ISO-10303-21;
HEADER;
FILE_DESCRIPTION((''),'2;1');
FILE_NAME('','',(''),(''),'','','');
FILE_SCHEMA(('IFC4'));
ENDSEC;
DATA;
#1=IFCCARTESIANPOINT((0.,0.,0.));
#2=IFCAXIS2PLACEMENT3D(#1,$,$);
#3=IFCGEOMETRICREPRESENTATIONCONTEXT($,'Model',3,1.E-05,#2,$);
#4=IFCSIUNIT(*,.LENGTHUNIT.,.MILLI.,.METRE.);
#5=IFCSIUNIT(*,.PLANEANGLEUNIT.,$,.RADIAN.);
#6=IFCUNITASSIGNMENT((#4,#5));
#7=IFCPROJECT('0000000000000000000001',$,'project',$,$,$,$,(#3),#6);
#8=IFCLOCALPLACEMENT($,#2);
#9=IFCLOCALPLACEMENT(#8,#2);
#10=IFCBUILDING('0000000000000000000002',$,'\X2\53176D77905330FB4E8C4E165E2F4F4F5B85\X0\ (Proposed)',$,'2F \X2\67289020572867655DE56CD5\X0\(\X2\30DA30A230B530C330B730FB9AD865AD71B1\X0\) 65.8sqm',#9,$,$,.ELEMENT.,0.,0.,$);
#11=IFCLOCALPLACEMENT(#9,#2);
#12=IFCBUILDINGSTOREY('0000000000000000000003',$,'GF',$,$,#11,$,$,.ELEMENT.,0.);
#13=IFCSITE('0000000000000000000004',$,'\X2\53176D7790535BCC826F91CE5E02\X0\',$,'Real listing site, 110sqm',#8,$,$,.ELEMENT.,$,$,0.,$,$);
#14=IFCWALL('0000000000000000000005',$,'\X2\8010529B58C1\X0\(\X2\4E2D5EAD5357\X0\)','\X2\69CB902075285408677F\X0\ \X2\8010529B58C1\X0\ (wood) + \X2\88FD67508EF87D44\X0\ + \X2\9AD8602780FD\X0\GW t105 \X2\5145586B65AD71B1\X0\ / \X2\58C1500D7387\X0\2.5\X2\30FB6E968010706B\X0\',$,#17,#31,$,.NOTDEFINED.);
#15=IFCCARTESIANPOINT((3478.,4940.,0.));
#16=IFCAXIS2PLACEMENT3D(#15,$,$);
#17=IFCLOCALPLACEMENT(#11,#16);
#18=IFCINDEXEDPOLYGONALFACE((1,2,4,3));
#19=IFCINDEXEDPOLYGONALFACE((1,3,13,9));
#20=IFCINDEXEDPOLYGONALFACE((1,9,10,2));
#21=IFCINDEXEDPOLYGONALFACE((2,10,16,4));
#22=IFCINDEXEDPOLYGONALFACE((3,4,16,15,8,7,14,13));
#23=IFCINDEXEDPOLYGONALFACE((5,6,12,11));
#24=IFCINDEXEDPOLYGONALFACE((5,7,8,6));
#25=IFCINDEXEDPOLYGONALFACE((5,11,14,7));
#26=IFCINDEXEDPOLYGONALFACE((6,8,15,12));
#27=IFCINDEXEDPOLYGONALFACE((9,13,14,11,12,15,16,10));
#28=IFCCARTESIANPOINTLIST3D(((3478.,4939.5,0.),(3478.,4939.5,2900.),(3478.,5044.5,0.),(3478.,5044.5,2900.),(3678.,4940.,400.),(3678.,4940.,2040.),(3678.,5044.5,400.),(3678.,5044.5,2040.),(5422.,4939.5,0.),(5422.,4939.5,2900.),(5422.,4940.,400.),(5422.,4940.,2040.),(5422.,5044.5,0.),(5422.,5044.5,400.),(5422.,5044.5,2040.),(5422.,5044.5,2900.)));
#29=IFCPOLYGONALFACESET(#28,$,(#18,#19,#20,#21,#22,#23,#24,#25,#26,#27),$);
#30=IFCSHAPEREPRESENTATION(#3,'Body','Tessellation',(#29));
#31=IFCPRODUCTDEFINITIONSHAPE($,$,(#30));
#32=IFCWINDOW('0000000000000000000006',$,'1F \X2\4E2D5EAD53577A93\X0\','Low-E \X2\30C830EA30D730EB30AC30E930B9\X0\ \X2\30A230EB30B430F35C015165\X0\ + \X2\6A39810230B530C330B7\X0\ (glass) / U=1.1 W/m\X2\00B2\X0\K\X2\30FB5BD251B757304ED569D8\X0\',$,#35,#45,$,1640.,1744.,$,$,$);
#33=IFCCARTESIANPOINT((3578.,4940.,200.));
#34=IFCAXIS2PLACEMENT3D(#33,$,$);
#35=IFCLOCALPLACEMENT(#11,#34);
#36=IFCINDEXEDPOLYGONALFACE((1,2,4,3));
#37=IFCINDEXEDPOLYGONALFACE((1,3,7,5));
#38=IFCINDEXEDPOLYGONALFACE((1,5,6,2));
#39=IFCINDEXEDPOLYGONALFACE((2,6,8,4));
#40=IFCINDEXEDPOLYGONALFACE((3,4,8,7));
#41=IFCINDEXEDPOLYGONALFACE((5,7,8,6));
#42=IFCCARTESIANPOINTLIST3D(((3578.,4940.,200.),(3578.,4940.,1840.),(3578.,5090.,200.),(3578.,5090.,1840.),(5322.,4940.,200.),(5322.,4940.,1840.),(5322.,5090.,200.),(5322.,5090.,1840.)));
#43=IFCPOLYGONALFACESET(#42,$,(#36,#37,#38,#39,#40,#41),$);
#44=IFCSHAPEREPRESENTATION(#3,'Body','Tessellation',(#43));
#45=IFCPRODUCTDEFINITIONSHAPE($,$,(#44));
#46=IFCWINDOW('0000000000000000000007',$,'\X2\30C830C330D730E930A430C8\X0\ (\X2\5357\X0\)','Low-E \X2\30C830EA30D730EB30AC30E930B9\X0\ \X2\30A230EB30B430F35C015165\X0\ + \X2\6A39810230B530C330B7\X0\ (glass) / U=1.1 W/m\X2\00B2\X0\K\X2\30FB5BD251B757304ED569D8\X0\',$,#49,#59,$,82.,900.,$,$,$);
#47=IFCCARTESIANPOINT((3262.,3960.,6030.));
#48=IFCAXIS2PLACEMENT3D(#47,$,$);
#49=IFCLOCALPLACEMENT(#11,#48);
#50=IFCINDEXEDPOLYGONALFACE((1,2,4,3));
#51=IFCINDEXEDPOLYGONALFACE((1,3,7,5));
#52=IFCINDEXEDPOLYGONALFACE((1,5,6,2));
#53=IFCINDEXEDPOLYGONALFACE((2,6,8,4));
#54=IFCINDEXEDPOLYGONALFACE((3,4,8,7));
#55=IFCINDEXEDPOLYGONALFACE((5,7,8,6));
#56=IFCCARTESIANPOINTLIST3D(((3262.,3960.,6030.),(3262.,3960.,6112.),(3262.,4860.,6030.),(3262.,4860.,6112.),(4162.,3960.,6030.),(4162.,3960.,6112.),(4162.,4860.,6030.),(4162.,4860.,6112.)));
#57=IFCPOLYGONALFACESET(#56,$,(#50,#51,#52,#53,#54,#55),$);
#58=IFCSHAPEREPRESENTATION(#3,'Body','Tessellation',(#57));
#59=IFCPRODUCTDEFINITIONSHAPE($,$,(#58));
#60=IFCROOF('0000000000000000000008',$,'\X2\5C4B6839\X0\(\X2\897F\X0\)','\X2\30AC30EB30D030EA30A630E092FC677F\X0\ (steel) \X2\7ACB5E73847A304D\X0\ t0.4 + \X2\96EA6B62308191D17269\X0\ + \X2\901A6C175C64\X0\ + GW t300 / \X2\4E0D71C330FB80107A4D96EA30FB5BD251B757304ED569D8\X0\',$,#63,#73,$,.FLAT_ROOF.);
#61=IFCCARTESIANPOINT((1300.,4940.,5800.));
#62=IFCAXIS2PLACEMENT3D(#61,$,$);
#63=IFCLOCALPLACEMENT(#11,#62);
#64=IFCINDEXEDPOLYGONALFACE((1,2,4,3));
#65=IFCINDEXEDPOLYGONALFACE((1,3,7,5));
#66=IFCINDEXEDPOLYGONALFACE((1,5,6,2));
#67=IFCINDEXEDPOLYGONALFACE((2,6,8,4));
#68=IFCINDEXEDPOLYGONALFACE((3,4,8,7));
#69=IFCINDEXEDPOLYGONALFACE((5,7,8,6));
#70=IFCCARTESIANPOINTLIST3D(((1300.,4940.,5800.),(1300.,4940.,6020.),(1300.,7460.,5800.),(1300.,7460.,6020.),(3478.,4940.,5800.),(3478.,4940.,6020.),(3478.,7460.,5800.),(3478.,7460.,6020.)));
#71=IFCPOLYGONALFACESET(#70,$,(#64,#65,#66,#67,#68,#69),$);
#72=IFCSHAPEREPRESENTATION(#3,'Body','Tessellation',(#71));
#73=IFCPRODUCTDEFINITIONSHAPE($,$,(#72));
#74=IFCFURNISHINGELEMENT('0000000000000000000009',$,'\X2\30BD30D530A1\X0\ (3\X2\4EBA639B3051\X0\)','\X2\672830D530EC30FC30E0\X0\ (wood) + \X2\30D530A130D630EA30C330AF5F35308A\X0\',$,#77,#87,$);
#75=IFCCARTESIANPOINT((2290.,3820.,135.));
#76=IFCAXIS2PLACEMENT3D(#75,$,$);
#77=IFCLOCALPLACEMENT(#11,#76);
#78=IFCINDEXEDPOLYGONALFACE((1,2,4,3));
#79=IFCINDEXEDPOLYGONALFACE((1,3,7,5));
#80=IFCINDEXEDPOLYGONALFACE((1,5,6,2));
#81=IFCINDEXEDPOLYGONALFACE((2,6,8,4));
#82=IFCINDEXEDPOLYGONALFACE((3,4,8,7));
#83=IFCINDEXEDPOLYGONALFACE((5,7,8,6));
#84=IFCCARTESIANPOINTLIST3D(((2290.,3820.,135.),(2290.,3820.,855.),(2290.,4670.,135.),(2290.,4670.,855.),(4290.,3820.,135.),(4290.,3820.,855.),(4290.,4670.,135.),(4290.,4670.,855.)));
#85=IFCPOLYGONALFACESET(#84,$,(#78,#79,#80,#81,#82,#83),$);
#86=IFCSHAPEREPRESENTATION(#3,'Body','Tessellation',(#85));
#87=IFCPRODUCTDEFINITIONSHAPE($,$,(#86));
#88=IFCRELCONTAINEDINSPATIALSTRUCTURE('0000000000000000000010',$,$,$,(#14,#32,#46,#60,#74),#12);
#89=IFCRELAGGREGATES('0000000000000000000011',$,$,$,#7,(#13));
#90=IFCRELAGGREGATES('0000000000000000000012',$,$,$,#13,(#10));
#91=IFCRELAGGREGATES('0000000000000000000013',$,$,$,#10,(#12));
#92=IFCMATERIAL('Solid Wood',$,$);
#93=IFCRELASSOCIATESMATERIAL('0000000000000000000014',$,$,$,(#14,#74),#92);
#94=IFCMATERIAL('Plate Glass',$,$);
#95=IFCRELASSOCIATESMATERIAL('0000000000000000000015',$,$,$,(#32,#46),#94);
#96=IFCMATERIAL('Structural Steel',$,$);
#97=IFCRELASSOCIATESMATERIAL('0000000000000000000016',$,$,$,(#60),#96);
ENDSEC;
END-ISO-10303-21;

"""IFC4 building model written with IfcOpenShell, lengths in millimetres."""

from ifc_helpers import new_model, si_unit, frame, frame_2d, origin, place, context, project, spatial, rectangle, extrude, material, element, fill, save


model = new_model("IFC4")

# Units and contexts
model_context = context("Model", 3, precision=1e-05, world=origin())
ifc_project = project(units=[si_unit("LENGTHUNIT", "METRE", prefix="MILLI"), si_unit("PLANEANGLEUNIT", "RADIAN")], contexts=[model_context])

# Site, building, storey
site_placement = place(None, origin())
site = spatial("IfcSite", under=ifc_project, at=site_placement, Name="北海道富良野市", ObjectType="Real listing site, 110sqm", CompositionType="ELEMENT", RefElevation=0.0)
building_placement = place(site_placement, origin())
building = spatial("IfcBuilding", under=site, at=building_placement, Name="北海道・二世帯住宅 (Proposed)", ObjectType="2F 木造在来工法(ペアサッシ・高断熱) 65.8sqm", CompositionType="ELEMENT", ElevationOfRefHeight=0.0, ElevationOfTerrain=0.0)
storey_placement = place(building_placement, origin())
storey = spatial("IfcBuildingStorey", under=building, at=storey_placement, Name="GF", CompositionType="ELEMENT", Elevation=0.0)

# Shared definitions
ifc_material_1 = material(Name="Solid Wood")

# Wall, opening, window
wall_1_placement = place(storey_placement, frame((3478.0, 4940.0, 0.0)))
wall_1 = element("IfcWall", 1, at=wall_1_placement, inside=storey, material=ifc_material_1, Name="耐力壁(中庭南)", Description="構造用合板 耐力壁 (wood) + 製材軸組 + 高性能GW t105 充填断熱 / 壁倍率2.5・準耐火", PredefinedType="NOTDEFINED", context=model_context, shape_type="SweptSolid", body=[
    extrude(rectangle(XDim=1944.0, YDim=105.0, at=frame_2d((972.0, 52.0))), frame((3478.0, 4940.0, 0.0)), (0.0, 0.0, 1.0), 2900.0),
])
opening_placement = place(storey_placement, frame((3578.0, 4940.0, 200.0)))
opening = element("IfcOpeningElement", 2, at=opening_placement, cuts=wall_1, PredefinedType="NOTDEFINED", context=model_context, shape_type="SweptSolid", body=[
    extrude(rectangle(XDim=1744.0, YDim=150.0, at=frame_2d((872.0, 75.0))), frame((3578.0, 4940.0, 200.0)), (0.0, 0.0, 1.0), 1640.0),
])
ifc_material_2 = material(Name="Plate Glass")
window_1_placement = place(storey_placement, frame((3578.0, 4940.0, 200.0)))
window_1 = element("IfcWindow", 3, at=window_1_placement, inside=storey, material=ifc_material_2, Name="1F 中庭南窓", Description="Low-E トリプルガラス アルゴン封入 + 樹脂サッシ (glass) / U=1.1 W/m²K・寒冷地仕様", OverallHeight=1640.0, OverallWidth=1744.0, context=model_context, shape_type="SweptSolid", body=[
    extrude(rectangle(XDim=1744.0, YDim=150.0, at=frame_2d((872.0, 75.0))), frame((3578.0, 4940.0, 200.0)), (0.0, 0.0, 1.0), 1640.0),
])
fill(opening, window_1)

# Window
window_2_placement = place(storey_placement, frame((3262.0, 3960.0, 6030.0)))
element("IfcWindow", 4, at=window_2_placement, inside=storey, material=ifc_material_2, Name="トップライト (南)", Description="Low-E トリプルガラス アルゴン封入 + 樹脂サッシ (glass) / U=1.1 W/m²K・寒冷地仕様", OverallHeight=82.0, OverallWidth=900.0, context=model_context, shape_type="SweptSolid", body=[
    extrude(rectangle(XDim=900.0, YDim=900.0, at=frame_2d((450.0, 450.0))), frame((3262.0, 3960.0, 6030.0)), (0.0, 0.0, 1.0), 82.0),
])

# Roof
ifc_material_3 = material(Name="Structural Steel")
for number, where, name in (
    (5, (1300.0, 4940.0, 5800.0), "屋根(西)"),
):
    element("IfcRoof", number, at=place(storey_placement, frame(where)), inside=storey, material=ifc_material_3, Name=name, Description="ガルバリウム鋼板 (steel) 立平葺き t0.4 + 雪止め金物 + 通気層 + GW t300 / 不燃・耐積雪・寒冷地仕様", PredefinedType="FLAT_ROOF", context=model_context, shape_type="SweptSolid", body=[
        extrude(rectangle(XDim=2178.0, YDim=2520.0, at=frame_2d((1089.0, 1260.0))), frame((1300.0, 4940.0, 5800.0)), (0.0, 0.0, 1.0), 220.0),
    ])

# Furnishing element
furnishing_placement = place(storey_placement, frame((2290.0, 3820.0, 135.0)))
element("IfcFurnishingElement", 6, at=furnishing_placement, inside=storey, material=ifc_material_1, Name="ソファ (3人掛け)", Description="木フレーム (wood) + ファブリック張り", context=model_context, shape_type="SweptSolid", body=[
    extrude(rectangle(XDim=2000.0, YDim=850.0, at=frame_2d((1000.0, 425.0))), frame((2290.0, 3820.0, 135.0)), (0.0, 0.0, 1.0), 720.0),
])

save(model, "model.ifc")
